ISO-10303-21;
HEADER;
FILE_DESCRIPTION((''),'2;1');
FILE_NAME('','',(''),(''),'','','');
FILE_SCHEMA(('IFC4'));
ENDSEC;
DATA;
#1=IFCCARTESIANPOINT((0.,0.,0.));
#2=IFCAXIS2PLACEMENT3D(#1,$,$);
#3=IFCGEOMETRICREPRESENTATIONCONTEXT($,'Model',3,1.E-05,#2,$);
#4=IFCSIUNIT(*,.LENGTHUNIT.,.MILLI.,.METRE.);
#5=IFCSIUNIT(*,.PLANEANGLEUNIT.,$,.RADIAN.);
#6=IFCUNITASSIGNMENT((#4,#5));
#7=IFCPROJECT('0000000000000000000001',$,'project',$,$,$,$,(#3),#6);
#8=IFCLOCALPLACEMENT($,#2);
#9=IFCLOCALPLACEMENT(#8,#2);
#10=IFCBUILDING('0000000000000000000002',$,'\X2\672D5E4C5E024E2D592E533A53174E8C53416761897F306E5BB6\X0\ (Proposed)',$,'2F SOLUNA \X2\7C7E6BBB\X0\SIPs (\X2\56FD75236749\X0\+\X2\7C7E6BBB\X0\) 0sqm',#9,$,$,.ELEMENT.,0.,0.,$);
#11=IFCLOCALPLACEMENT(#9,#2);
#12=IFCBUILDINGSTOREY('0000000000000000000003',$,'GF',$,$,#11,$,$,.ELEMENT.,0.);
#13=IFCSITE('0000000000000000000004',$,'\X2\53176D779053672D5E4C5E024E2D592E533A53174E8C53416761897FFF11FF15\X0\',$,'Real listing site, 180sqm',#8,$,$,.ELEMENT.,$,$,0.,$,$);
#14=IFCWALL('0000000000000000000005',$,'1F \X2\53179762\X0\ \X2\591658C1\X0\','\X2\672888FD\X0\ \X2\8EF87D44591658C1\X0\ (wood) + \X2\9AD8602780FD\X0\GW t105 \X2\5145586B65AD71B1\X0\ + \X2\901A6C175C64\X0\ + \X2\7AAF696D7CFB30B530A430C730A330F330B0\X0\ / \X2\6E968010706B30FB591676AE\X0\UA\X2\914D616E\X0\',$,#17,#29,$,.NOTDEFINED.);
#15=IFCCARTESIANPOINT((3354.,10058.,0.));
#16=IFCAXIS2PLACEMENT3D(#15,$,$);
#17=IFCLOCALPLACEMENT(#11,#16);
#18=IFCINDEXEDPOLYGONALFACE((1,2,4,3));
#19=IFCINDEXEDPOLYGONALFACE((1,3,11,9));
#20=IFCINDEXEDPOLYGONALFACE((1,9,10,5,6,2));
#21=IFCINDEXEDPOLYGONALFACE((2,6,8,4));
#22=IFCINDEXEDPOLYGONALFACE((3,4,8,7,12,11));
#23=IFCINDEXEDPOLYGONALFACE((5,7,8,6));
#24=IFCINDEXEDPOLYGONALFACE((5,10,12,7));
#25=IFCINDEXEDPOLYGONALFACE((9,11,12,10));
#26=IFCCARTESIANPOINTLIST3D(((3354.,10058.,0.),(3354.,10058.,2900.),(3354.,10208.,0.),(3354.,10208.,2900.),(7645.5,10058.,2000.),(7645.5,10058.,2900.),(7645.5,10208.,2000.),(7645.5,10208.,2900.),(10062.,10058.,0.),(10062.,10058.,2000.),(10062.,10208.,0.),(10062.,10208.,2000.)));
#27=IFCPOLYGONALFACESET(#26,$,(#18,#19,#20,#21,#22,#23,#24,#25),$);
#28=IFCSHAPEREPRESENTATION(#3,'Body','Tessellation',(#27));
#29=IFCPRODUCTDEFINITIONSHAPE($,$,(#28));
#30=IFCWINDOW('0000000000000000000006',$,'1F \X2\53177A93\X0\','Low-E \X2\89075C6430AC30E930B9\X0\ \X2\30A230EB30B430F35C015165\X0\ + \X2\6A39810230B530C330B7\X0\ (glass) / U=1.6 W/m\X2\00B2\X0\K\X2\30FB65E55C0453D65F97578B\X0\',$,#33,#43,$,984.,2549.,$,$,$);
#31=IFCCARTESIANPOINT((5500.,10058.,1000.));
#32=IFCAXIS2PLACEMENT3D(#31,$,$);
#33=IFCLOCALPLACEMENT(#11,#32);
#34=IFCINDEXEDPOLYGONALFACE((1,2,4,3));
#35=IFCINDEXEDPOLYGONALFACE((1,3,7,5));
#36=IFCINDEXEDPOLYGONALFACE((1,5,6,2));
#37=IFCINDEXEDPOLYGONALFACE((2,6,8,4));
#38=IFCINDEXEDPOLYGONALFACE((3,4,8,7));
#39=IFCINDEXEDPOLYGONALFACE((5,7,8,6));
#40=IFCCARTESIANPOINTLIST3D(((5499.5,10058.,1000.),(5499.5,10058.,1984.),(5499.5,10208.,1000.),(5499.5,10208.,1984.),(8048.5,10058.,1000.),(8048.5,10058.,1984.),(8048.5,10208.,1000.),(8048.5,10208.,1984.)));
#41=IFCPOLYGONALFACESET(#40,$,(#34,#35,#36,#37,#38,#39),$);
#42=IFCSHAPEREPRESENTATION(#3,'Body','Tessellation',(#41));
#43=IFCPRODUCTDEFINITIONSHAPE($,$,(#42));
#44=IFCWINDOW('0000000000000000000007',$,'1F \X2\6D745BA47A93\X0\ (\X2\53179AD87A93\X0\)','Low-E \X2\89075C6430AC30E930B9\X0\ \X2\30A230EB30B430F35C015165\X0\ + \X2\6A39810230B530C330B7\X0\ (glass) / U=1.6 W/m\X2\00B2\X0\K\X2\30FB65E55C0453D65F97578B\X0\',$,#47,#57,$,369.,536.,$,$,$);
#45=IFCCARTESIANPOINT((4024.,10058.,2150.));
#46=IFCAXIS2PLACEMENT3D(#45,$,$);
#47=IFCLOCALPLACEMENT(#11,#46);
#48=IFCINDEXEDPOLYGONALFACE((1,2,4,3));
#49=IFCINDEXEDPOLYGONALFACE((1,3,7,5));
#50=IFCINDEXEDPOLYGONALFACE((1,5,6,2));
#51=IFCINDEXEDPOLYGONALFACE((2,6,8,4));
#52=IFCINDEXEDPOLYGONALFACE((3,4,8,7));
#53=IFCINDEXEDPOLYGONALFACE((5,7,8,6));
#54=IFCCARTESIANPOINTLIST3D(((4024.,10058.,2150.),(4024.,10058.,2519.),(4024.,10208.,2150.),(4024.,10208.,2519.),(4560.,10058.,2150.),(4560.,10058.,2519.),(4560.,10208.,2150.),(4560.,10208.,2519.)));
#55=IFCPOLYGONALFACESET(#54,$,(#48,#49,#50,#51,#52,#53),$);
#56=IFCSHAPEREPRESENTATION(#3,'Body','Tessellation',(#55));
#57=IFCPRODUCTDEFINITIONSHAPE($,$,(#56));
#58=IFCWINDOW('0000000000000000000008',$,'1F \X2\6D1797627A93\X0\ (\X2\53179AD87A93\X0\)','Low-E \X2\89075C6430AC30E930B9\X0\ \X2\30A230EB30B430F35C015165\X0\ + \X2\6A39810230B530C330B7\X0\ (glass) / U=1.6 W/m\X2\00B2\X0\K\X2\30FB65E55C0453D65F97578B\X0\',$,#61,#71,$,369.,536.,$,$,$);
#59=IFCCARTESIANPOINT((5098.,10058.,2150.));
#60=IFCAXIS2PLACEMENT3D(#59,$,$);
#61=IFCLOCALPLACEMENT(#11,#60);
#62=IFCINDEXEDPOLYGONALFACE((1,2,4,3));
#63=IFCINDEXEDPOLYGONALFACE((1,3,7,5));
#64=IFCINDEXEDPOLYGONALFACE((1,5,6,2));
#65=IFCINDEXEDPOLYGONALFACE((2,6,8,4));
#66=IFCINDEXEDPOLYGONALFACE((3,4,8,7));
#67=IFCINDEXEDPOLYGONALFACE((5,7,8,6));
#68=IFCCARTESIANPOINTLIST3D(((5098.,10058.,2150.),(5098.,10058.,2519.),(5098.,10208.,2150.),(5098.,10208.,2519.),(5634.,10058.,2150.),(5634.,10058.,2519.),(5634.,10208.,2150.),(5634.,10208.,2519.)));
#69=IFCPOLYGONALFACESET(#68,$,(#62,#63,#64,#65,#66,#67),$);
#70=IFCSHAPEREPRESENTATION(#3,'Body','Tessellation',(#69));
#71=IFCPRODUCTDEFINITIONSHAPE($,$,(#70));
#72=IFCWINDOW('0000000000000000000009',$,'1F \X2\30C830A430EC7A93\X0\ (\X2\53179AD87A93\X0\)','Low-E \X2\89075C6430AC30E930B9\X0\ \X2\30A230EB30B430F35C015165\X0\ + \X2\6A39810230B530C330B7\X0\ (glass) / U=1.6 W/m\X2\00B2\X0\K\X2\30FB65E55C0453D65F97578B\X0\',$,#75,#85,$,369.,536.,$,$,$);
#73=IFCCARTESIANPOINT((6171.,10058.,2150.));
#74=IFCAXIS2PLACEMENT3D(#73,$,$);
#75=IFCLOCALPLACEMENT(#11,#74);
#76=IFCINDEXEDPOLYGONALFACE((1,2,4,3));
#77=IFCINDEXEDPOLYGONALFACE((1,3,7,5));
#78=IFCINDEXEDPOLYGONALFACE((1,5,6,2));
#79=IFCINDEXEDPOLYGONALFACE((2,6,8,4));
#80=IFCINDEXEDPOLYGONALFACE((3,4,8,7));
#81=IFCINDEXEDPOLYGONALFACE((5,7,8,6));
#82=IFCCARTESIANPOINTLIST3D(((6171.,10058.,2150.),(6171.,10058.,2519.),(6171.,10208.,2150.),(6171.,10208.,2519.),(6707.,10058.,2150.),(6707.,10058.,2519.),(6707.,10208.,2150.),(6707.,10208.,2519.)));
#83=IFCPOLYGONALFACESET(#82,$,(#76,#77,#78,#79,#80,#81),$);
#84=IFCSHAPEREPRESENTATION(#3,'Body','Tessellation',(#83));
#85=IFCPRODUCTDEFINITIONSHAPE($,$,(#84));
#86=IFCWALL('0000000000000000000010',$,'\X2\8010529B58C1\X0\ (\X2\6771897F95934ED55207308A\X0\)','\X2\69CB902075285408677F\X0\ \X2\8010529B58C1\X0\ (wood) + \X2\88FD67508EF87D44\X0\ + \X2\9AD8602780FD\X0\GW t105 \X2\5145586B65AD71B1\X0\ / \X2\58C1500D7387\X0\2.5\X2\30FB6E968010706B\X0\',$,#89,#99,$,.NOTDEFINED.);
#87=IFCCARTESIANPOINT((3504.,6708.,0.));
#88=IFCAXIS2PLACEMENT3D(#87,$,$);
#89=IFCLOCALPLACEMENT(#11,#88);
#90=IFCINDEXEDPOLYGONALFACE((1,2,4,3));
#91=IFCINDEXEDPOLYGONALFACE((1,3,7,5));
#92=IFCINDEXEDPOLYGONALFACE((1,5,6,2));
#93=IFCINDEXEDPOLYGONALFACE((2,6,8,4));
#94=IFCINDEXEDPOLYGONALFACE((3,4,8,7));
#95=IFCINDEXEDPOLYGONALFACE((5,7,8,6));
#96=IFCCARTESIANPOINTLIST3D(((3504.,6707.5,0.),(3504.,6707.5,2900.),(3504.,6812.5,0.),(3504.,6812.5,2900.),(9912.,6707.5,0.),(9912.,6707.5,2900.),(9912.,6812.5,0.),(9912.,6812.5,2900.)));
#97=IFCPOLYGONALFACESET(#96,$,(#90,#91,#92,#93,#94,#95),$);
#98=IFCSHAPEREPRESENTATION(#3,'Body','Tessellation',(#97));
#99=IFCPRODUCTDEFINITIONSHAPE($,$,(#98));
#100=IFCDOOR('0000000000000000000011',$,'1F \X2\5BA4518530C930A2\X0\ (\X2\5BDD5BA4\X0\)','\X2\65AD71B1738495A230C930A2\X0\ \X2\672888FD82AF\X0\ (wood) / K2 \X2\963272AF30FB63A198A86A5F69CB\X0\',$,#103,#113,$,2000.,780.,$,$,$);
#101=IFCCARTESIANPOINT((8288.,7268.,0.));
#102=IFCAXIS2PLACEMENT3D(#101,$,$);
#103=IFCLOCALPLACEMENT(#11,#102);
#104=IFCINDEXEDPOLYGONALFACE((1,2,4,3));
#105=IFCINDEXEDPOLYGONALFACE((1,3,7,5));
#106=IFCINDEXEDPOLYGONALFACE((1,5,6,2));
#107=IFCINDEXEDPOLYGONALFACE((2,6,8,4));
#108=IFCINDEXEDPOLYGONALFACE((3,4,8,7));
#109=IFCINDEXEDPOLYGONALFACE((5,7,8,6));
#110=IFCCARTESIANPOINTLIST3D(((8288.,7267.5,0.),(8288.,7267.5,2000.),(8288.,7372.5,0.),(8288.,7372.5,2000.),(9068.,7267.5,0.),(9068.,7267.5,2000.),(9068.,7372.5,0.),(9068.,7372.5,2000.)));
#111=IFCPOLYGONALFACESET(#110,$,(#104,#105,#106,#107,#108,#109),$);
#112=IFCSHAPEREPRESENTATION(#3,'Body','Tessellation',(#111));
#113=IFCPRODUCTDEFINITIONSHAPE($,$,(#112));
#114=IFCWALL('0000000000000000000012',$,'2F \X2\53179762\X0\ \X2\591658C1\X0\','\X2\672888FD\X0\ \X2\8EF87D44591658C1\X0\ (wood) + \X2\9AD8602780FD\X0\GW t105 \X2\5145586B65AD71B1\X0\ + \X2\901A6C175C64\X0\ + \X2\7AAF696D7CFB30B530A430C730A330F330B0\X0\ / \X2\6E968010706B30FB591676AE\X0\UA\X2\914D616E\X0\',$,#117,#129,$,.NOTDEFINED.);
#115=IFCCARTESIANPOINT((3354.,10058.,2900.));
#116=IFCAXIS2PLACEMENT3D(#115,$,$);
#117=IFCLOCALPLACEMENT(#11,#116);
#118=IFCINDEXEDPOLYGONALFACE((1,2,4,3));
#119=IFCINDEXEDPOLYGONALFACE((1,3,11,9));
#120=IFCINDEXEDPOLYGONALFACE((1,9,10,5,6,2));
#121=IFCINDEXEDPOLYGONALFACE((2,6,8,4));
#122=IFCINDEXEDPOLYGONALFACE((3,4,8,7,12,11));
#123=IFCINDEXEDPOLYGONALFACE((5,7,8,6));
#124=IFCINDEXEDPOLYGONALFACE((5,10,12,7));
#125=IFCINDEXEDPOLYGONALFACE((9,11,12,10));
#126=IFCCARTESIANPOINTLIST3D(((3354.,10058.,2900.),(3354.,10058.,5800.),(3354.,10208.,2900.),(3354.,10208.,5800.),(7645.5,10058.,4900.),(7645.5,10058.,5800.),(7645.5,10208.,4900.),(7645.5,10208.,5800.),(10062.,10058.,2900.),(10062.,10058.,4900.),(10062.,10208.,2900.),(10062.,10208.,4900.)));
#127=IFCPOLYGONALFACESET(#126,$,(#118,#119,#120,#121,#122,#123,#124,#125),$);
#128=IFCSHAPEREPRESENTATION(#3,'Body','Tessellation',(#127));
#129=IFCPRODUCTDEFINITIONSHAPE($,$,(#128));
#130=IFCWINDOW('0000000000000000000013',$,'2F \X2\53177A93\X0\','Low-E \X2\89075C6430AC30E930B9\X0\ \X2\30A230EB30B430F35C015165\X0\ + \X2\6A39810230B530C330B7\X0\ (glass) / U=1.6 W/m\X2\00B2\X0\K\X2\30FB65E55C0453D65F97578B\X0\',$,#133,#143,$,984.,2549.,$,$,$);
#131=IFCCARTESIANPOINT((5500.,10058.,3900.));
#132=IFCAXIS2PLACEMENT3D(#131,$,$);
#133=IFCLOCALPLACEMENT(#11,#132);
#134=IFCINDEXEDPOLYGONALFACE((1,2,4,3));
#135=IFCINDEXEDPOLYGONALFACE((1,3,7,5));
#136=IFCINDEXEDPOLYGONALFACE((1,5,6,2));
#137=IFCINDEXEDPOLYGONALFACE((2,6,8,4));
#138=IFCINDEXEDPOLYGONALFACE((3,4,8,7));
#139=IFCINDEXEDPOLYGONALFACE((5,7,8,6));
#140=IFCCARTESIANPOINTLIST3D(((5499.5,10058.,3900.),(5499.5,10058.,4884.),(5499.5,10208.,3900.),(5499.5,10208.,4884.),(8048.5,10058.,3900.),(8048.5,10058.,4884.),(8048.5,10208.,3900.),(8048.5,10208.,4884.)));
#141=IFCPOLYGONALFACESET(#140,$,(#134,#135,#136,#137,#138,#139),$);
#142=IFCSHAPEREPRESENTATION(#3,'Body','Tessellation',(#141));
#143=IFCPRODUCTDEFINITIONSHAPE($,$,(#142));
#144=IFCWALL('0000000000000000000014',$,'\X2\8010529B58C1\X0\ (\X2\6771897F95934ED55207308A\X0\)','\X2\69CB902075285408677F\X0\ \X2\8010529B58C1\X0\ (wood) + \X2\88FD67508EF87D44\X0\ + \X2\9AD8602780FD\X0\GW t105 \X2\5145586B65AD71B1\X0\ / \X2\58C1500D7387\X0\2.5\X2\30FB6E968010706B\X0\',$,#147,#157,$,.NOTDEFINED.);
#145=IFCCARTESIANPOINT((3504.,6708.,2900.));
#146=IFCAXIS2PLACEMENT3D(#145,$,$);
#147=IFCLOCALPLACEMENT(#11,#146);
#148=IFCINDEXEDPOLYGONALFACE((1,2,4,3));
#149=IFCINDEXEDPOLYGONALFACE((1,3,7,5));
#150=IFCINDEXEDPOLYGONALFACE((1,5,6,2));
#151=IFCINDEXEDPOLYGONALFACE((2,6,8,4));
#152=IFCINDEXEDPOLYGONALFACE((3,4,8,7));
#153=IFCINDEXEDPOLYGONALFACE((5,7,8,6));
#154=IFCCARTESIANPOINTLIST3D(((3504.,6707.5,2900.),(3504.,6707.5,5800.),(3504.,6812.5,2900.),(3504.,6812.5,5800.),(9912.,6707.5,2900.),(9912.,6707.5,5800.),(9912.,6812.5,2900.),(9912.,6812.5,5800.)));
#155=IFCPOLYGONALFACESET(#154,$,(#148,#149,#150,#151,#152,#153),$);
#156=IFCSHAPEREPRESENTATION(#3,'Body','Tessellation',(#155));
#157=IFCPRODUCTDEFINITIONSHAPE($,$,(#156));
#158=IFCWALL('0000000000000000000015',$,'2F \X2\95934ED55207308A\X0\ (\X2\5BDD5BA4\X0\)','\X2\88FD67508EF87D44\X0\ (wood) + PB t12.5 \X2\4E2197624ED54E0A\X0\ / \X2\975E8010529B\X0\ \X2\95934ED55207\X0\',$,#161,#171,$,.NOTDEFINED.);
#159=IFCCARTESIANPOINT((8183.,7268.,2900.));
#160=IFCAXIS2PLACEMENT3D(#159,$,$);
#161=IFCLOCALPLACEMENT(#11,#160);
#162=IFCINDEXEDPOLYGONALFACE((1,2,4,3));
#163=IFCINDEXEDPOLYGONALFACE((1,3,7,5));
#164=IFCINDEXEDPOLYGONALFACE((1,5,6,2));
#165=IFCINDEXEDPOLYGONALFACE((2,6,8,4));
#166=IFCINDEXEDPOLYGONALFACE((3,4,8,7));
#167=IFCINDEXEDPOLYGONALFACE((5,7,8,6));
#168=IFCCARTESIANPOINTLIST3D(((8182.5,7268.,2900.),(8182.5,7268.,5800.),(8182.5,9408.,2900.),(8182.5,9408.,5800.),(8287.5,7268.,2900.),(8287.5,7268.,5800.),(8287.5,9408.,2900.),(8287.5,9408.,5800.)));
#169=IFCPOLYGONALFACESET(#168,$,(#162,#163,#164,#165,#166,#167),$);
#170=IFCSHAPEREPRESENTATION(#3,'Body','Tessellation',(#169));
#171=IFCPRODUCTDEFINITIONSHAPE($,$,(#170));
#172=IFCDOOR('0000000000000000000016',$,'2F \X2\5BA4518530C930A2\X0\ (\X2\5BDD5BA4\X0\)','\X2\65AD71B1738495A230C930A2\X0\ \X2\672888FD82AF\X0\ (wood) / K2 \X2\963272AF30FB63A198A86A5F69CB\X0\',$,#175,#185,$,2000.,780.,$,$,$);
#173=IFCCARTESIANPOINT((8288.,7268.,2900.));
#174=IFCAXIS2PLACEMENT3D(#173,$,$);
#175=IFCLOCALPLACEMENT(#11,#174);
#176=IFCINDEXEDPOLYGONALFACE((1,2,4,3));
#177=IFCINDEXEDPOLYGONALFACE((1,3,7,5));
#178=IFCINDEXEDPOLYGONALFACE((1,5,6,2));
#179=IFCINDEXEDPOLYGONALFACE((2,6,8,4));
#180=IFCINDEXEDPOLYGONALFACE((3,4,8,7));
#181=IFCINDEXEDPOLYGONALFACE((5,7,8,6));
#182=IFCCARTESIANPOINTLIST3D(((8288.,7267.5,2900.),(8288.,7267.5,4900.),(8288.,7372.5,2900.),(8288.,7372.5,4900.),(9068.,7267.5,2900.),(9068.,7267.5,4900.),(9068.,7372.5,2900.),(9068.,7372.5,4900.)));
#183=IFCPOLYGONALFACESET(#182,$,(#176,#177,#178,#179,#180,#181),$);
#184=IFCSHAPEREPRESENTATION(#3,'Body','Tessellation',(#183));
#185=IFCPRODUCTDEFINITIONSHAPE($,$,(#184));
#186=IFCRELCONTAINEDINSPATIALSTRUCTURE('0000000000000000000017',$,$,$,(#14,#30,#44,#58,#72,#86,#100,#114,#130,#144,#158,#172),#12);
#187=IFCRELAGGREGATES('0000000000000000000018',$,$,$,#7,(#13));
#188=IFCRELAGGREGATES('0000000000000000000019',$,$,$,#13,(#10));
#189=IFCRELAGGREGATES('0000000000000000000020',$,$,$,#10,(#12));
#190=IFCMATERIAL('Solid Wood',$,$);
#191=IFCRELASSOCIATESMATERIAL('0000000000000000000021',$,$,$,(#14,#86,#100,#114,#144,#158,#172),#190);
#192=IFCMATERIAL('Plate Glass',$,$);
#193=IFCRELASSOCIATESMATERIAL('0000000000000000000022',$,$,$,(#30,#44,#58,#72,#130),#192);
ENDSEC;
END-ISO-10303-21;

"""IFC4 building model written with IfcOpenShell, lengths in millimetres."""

from ifc_helpers import new_model, si_unit, frame, frame_2d, origin, place, context, project, spatial, rectangle, extrude, material, element, fill, save


model = new_model("IFC4")

# Units and contexts
model_context = context("Model", 3, precision=1e-05, world=origin())
ifc_project = project(units=[si_unit("LENGTHUNIT", "METRE", prefix="MILLI"), si_unit("PLANEANGLEUNIT", "RADIAN")], contexts=[model_context])

# Site, building, storey
site_placement = place(None, origin())
site = spatial("IfcSite", under=ifc_project, at=site_placement, Name="北海道札幌市中央区北二十条西１５", ObjectType="Real listing site, 180sqm", CompositionType="ELEMENT", RefElevation=0.0)
building_placement = place(site_placement, origin())
building = spatial("IfcBuilding", under=site, at=building_placement, Name="札幌市中央区北二十条西の家 (Proposed)", ObjectType="2F SOLUNA 籾殻SIPs (国産杉+籾殻) 0sqm", CompositionType="ELEMENT", ElevationOfRefHeight=0.0, ElevationOfTerrain=0.0)
storey_placement = place(building_placement, origin())
storey = spatial("IfcBuildingStorey", under=building, at=storey_placement, Name="GF", CompositionType="ELEMENT", Elevation=0.0)

# Wall, openings, windows
ifc_material_1 = material(Name="Solid Wood")
wall_1_placement = place(storey_placement, frame((3354.0, 10058.0, 0.0)))
wall_1 = element("IfcWall", 1, at=wall_1_placement, inside=storey, material=ifc_material_1, Name="1F 北面 外壁", Description="木製 軸組外壁 (wood) + 高性能GW t105 充填断熱 + 通気層 + 窯業系サイディング / 準耐火・外皮UA配慮", PredefinedType="NOTDEFINED", context=model_context, shape_type="SweptSolid", body=[
    extrude(rectangle(XDim=6708.0, YDim=150.0, at=frame_2d((3354.0, 75.0))), frame((3354.0, 10058.0, 0.0)), (0.0, 0.0, 1.0), 2900.0),
])
opening_1_placement = place(storey_placement, frame((5500.0, 10058.0, 1000.0)))
opening_1 = element("IfcOpeningElement", 2, at=opening_1_placement, cuts=wall_1, PredefinedType="NOTDEFINED", context=model_context, shape_type="SweptSolid", body=[
    extrude(rectangle(XDim=2549.0, YDim=150.0, at=frame_2d((1274.0, 75.0))), frame((5500.0, 10058.0, 1000.0)), (0.0, 0.0, 1.0), 984.0),
])
opening_2_placement = place(storey_placement, frame((4024.0, 10058.0, 2150.0)))
opening_2 = element("IfcOpeningElement", 3, at=opening_2_placement, cuts=wall_1, PredefinedType="NOTDEFINED", context=model_context, shape_type="SweptSolid", body=[
    extrude(rectangle(XDim=536.0, YDim=150.0, at=frame_2d((268.0, 75.0))), frame((4024.0, 10058.0, 2150.0)), (0.0, 0.0, 1.0), 369.0),
])
opening_3_placement = place(storey_placement, frame((5098.0, 10058.0, 2150.0)))
opening_3 = element("IfcOpeningElement", 4, at=opening_3_placement, cuts=wall_1, PredefinedType="NOTDEFINED", context=model_context, shape_type="SweptSolid", body=[
    extrude(rectangle(XDim=536.0, YDim=150.0, at=frame_2d((268.0, 75.0))), frame((5098.0, 10058.0, 2150.0)), (0.0, 0.0, 1.0), 369.0),
])
opening_4_placement = place(storey_placement, frame((6171.0, 10058.0, 2150.0)))
opening_4 = element("IfcOpeningElement", 5, at=opening_4_placement, cuts=wall_1, PredefinedType="NOTDEFINED", context=model_context, shape_type="SweptSolid", body=[
    extrude(rectangle(XDim=536.0, YDim=150.0, at=frame_2d((268.0, 75.0))), frame((6171.0, 10058.0, 2150.0)), (0.0, 0.0, 1.0), 369.0),
])
ifc_material_2 = material(Name="Plate Glass")
window_1_placement = place(storey_placement, frame((5500.0, 10058.0, 1000.0)))
window_1 = element("IfcWindow", 6, at=window_1_placement, inside=storey, material=ifc_material_2, Name="1F 北窓", Description="Low-E 複層ガラス アルゴン封入 + 樹脂サッシ (glass) / U=1.6 W/m²K・日射取得型", OverallHeight=984.0, OverallWidth=2549.0, context=model_context, shape_type="SweptSolid", body=[
    extrude(rectangle(XDim=2549.0, YDim=150.0, at=frame_2d((1274.0, 75.0))), frame((5500.0, 10058.0, 1000.0)), (0.0, 0.0, 1.0), 984.0),
])
fill(opening_1, window_1)
window_2_placement = place(storey_placement, frame((4024.0, 10058.0, 2150.0)))
window_2 = element("IfcWindow", 7, at=window_2_placement, inside=storey, material=ifc_material_2, Name="1F 浴室窓 (北高窓)", Description="Low-E 複層ガラス アルゴン封入 + 樹脂サッシ (glass) / U=1.6 W/m²K・日射取得型", OverallHeight=369.0, OverallWidth=536.0, context=model_context, shape_type="SweptSolid", body=[
    extrude(rectangle(XDim=536.0, YDim=150.0, at=frame_2d((268.0, 75.0))), frame((4024.0, 10058.0, 2150.0)), (0.0, 0.0, 1.0), 369.0),
])
fill(opening_2, window_2)
window_3_placement = place(storey_placement, frame((5098.0, 10058.0, 2150.0)))
window_3 = element("IfcWindow", 8, at=window_3_placement, inside=storey, material=ifc_material_2, Name="1F 洗面窓 (北高窓)", Description="Low-E 複層ガラス アルゴン封入 + 樹脂サッシ (glass) / U=1.6 W/m²K・日射取得型", OverallHeight=369.0, OverallWidth=536.0, context=model_context, shape_type="SweptSolid", body=[
    extrude(rectangle(XDim=536.0, YDim=150.0, at=frame_2d((268.0, 75.0))), frame((5098.0, 10058.0, 2150.0)), (0.0, 0.0, 1.0), 369.0),
])
fill(opening_3, window_3)
window_4_placement = place(storey_placement, frame((6171.0, 10058.0, 2150.0)))
window_4 = element("IfcWindow", 9, at=window_4_placement, inside=storey, material=ifc_material_2, Name="1F トイレ窓 (北高窓)", Description="Low-E 複層ガラス アルゴン封入 + 樹脂サッシ (glass) / U=1.6 W/m²K・日射取得型", OverallHeight=369.0, OverallWidth=536.0, context=model_context, shape_type="SweptSolid", body=[
    extrude(rectangle(XDim=536.0, YDim=150.0, at=frame_2d((268.0, 75.0))), frame((6171.0, 10058.0, 2150.0)), (0.0, 0.0, 1.0), 369.0),
])
fill(opening_4, window_4)

# Wall
wall_2_placement = place(storey_placement, frame((3504.0, 6708.0, 0.0)))
element("IfcWall", 10, at=wall_2_placement, inside=storey, material=ifc_material_1, Name="耐力壁 (東西間仕切り)", Description="構造用合板 耐力壁 (wood) + 製材軸組 + 高性能GW t105 充填断熱 / 壁倍率2.5・準耐火", PredefinedType="NOTDEFINED", context=model_context, shape_type="SweptSolid", body=[
    extrude(rectangle(XDim=6408.0, YDim=105.0, at=frame_2d((3204.0, 52.0))), frame((3504.0, 6708.0, 0.0)), (0.0, 0.0, 1.0), 2900.0),
])

# Door
door_1_placement = place(storey_placement, frame((8288.0, 7268.0, 0.0)))
element("IfcDoor", 11, at=door_1_placement, inside=storey, material=ifc_material_1, Name="1F 室内ドア (寝室)", Description="断熱玄関ドア 木製芯 (wood) / K2 防犯・採風機構", OverallHeight=2000.0, OverallWidth=780.0, context=model_context, shape_type="SweptSolid", body=[
    extrude(rectangle(XDim=780.0, YDim=105.0, at=frame_2d((390.0, 52.0))), frame((8288.0, 7268.0, 0.0)), (0.0, 0.0, 1.0), 2000.0),
])

# Wall, opening, window
wall_3_placement = place(storey_placement, frame((3354.0, 10058.0, 2900.0)))
wall_3 = element("IfcWall", 12, at=wall_3_placement, inside=storey, material=ifc_material_1, Name="2F 北面 外壁", Description="木製 軸組外壁 (wood) + 高性能GW t105 充填断熱 + 通気層 + 窯業系サイディング / 準耐火・外皮UA配慮", PredefinedType="NOTDEFINED", context=model_context, shape_type="SweptSolid", body=[
    extrude(rectangle(XDim=6708.0, YDim=150.0, at=frame_2d((3354.0, 75.0))), frame((3354.0, 10058.0, 2900.0)), (0.0, 0.0, 1.0), 2900.0),
])
opening_5_placement = place(storey_placement, frame((5500.0, 10058.0, 3900.0)))
opening_5 = element("IfcOpeningElement", 13, at=opening_5_placement, cuts=wall_3, PredefinedType="NOTDEFINED", context=model_context, shape_type="SweptSolid", body=[
    extrude(rectangle(XDim=2549.0, YDim=150.0, at=frame_2d((1274.0, 75.0))), frame((5500.0, 10058.0, 3900.0)), (0.0, 0.0, 1.0), 984.0),
])
window_5_placement = place(storey_placement, frame((5500.0, 10058.0, 3900.0)))
window_5 = element("IfcWindow", 14, at=window_5_placement, inside=storey, material=ifc_material_2, Name="2F 北窓", Description="Low-E 複層ガラス アルゴン封入 + 樹脂サッシ (glass) / U=1.6 W/m²K・日射取得型", OverallHeight=984.0, OverallWidth=2549.0, context=model_context, shape_type="SweptSolid", body=[
    extrude(rectangle(XDim=2549.0, YDim=150.0, at=frame_2d((1274.0, 75.0))), frame((5500.0, 10058.0, 3900.0)), (0.0, 0.0, 1.0), 984.0),
])
fill(opening_5, window_5)

# Walls
wall_4_placement = place(storey_placement, frame((3504.0, 6708.0, 2900.0)))
element("IfcWall", 15, at=wall_4_placement, inside=storey, material=ifc_material_1, Name="耐力壁 (東西間仕切り)", Description="構造用合板 耐力壁 (wood) + 製材軸組 + 高性能GW t105 充填断熱 / 壁倍率2.5・準耐火", PredefinedType="NOTDEFINED", context=model_context, shape_type="SweptSolid", body=[
    extrude(rectangle(XDim=6408.0, YDim=105.0, at=frame_2d((3204.0, 52.0))), frame((3504.0, 6708.0, 2900.0)), (0.0, 0.0, 1.0), 2900.0),
])
wall_5_placement = place(storey_placement, frame((8183.0, 7268.0, 2900.0)))
element("IfcWall", 16, at=wall_5_placement, inside=storey, material=ifc_material_1, Name="2F 間仕切り (寝室)", Description="製材軸組 (wood) + PB t12.5 両面仕上 / 非耐力 間仕切", PredefinedType="NOTDEFINED", context=model_context, shape_type="SweptSolid", body=[
    extrude(rectangle(XDim=105.0, YDim=2140.0, at=frame_2d((52.0, 1070.0))), frame((8183.0, 7268.0, 2900.0)), (0.0, 0.0, 1.0), 2900.0),
])

# Door
door_2_placement = place(storey_placement, frame((8288.0, 7268.0, 2900.0)))
element("IfcDoor", 17, at=door_2_placement, inside=storey, material=ifc_material_1, Name="2F 室内ドア (寝室)", Description="断熱玄関ドア 木製芯 (wood) / K2 防犯・採風機構", OverallHeight=2000.0, OverallWidth=780.0, context=model_context, shape_type="SweptSolid", body=[
    extrude(rectangle(XDim=780.0, YDim=105.0, at=frame_2d((390.0, 52.0))), frame((8288.0, 7268.0, 2900.0)), (0.0, 0.0, 1.0), 2000.0),
])

save(model, "model.ifc")
